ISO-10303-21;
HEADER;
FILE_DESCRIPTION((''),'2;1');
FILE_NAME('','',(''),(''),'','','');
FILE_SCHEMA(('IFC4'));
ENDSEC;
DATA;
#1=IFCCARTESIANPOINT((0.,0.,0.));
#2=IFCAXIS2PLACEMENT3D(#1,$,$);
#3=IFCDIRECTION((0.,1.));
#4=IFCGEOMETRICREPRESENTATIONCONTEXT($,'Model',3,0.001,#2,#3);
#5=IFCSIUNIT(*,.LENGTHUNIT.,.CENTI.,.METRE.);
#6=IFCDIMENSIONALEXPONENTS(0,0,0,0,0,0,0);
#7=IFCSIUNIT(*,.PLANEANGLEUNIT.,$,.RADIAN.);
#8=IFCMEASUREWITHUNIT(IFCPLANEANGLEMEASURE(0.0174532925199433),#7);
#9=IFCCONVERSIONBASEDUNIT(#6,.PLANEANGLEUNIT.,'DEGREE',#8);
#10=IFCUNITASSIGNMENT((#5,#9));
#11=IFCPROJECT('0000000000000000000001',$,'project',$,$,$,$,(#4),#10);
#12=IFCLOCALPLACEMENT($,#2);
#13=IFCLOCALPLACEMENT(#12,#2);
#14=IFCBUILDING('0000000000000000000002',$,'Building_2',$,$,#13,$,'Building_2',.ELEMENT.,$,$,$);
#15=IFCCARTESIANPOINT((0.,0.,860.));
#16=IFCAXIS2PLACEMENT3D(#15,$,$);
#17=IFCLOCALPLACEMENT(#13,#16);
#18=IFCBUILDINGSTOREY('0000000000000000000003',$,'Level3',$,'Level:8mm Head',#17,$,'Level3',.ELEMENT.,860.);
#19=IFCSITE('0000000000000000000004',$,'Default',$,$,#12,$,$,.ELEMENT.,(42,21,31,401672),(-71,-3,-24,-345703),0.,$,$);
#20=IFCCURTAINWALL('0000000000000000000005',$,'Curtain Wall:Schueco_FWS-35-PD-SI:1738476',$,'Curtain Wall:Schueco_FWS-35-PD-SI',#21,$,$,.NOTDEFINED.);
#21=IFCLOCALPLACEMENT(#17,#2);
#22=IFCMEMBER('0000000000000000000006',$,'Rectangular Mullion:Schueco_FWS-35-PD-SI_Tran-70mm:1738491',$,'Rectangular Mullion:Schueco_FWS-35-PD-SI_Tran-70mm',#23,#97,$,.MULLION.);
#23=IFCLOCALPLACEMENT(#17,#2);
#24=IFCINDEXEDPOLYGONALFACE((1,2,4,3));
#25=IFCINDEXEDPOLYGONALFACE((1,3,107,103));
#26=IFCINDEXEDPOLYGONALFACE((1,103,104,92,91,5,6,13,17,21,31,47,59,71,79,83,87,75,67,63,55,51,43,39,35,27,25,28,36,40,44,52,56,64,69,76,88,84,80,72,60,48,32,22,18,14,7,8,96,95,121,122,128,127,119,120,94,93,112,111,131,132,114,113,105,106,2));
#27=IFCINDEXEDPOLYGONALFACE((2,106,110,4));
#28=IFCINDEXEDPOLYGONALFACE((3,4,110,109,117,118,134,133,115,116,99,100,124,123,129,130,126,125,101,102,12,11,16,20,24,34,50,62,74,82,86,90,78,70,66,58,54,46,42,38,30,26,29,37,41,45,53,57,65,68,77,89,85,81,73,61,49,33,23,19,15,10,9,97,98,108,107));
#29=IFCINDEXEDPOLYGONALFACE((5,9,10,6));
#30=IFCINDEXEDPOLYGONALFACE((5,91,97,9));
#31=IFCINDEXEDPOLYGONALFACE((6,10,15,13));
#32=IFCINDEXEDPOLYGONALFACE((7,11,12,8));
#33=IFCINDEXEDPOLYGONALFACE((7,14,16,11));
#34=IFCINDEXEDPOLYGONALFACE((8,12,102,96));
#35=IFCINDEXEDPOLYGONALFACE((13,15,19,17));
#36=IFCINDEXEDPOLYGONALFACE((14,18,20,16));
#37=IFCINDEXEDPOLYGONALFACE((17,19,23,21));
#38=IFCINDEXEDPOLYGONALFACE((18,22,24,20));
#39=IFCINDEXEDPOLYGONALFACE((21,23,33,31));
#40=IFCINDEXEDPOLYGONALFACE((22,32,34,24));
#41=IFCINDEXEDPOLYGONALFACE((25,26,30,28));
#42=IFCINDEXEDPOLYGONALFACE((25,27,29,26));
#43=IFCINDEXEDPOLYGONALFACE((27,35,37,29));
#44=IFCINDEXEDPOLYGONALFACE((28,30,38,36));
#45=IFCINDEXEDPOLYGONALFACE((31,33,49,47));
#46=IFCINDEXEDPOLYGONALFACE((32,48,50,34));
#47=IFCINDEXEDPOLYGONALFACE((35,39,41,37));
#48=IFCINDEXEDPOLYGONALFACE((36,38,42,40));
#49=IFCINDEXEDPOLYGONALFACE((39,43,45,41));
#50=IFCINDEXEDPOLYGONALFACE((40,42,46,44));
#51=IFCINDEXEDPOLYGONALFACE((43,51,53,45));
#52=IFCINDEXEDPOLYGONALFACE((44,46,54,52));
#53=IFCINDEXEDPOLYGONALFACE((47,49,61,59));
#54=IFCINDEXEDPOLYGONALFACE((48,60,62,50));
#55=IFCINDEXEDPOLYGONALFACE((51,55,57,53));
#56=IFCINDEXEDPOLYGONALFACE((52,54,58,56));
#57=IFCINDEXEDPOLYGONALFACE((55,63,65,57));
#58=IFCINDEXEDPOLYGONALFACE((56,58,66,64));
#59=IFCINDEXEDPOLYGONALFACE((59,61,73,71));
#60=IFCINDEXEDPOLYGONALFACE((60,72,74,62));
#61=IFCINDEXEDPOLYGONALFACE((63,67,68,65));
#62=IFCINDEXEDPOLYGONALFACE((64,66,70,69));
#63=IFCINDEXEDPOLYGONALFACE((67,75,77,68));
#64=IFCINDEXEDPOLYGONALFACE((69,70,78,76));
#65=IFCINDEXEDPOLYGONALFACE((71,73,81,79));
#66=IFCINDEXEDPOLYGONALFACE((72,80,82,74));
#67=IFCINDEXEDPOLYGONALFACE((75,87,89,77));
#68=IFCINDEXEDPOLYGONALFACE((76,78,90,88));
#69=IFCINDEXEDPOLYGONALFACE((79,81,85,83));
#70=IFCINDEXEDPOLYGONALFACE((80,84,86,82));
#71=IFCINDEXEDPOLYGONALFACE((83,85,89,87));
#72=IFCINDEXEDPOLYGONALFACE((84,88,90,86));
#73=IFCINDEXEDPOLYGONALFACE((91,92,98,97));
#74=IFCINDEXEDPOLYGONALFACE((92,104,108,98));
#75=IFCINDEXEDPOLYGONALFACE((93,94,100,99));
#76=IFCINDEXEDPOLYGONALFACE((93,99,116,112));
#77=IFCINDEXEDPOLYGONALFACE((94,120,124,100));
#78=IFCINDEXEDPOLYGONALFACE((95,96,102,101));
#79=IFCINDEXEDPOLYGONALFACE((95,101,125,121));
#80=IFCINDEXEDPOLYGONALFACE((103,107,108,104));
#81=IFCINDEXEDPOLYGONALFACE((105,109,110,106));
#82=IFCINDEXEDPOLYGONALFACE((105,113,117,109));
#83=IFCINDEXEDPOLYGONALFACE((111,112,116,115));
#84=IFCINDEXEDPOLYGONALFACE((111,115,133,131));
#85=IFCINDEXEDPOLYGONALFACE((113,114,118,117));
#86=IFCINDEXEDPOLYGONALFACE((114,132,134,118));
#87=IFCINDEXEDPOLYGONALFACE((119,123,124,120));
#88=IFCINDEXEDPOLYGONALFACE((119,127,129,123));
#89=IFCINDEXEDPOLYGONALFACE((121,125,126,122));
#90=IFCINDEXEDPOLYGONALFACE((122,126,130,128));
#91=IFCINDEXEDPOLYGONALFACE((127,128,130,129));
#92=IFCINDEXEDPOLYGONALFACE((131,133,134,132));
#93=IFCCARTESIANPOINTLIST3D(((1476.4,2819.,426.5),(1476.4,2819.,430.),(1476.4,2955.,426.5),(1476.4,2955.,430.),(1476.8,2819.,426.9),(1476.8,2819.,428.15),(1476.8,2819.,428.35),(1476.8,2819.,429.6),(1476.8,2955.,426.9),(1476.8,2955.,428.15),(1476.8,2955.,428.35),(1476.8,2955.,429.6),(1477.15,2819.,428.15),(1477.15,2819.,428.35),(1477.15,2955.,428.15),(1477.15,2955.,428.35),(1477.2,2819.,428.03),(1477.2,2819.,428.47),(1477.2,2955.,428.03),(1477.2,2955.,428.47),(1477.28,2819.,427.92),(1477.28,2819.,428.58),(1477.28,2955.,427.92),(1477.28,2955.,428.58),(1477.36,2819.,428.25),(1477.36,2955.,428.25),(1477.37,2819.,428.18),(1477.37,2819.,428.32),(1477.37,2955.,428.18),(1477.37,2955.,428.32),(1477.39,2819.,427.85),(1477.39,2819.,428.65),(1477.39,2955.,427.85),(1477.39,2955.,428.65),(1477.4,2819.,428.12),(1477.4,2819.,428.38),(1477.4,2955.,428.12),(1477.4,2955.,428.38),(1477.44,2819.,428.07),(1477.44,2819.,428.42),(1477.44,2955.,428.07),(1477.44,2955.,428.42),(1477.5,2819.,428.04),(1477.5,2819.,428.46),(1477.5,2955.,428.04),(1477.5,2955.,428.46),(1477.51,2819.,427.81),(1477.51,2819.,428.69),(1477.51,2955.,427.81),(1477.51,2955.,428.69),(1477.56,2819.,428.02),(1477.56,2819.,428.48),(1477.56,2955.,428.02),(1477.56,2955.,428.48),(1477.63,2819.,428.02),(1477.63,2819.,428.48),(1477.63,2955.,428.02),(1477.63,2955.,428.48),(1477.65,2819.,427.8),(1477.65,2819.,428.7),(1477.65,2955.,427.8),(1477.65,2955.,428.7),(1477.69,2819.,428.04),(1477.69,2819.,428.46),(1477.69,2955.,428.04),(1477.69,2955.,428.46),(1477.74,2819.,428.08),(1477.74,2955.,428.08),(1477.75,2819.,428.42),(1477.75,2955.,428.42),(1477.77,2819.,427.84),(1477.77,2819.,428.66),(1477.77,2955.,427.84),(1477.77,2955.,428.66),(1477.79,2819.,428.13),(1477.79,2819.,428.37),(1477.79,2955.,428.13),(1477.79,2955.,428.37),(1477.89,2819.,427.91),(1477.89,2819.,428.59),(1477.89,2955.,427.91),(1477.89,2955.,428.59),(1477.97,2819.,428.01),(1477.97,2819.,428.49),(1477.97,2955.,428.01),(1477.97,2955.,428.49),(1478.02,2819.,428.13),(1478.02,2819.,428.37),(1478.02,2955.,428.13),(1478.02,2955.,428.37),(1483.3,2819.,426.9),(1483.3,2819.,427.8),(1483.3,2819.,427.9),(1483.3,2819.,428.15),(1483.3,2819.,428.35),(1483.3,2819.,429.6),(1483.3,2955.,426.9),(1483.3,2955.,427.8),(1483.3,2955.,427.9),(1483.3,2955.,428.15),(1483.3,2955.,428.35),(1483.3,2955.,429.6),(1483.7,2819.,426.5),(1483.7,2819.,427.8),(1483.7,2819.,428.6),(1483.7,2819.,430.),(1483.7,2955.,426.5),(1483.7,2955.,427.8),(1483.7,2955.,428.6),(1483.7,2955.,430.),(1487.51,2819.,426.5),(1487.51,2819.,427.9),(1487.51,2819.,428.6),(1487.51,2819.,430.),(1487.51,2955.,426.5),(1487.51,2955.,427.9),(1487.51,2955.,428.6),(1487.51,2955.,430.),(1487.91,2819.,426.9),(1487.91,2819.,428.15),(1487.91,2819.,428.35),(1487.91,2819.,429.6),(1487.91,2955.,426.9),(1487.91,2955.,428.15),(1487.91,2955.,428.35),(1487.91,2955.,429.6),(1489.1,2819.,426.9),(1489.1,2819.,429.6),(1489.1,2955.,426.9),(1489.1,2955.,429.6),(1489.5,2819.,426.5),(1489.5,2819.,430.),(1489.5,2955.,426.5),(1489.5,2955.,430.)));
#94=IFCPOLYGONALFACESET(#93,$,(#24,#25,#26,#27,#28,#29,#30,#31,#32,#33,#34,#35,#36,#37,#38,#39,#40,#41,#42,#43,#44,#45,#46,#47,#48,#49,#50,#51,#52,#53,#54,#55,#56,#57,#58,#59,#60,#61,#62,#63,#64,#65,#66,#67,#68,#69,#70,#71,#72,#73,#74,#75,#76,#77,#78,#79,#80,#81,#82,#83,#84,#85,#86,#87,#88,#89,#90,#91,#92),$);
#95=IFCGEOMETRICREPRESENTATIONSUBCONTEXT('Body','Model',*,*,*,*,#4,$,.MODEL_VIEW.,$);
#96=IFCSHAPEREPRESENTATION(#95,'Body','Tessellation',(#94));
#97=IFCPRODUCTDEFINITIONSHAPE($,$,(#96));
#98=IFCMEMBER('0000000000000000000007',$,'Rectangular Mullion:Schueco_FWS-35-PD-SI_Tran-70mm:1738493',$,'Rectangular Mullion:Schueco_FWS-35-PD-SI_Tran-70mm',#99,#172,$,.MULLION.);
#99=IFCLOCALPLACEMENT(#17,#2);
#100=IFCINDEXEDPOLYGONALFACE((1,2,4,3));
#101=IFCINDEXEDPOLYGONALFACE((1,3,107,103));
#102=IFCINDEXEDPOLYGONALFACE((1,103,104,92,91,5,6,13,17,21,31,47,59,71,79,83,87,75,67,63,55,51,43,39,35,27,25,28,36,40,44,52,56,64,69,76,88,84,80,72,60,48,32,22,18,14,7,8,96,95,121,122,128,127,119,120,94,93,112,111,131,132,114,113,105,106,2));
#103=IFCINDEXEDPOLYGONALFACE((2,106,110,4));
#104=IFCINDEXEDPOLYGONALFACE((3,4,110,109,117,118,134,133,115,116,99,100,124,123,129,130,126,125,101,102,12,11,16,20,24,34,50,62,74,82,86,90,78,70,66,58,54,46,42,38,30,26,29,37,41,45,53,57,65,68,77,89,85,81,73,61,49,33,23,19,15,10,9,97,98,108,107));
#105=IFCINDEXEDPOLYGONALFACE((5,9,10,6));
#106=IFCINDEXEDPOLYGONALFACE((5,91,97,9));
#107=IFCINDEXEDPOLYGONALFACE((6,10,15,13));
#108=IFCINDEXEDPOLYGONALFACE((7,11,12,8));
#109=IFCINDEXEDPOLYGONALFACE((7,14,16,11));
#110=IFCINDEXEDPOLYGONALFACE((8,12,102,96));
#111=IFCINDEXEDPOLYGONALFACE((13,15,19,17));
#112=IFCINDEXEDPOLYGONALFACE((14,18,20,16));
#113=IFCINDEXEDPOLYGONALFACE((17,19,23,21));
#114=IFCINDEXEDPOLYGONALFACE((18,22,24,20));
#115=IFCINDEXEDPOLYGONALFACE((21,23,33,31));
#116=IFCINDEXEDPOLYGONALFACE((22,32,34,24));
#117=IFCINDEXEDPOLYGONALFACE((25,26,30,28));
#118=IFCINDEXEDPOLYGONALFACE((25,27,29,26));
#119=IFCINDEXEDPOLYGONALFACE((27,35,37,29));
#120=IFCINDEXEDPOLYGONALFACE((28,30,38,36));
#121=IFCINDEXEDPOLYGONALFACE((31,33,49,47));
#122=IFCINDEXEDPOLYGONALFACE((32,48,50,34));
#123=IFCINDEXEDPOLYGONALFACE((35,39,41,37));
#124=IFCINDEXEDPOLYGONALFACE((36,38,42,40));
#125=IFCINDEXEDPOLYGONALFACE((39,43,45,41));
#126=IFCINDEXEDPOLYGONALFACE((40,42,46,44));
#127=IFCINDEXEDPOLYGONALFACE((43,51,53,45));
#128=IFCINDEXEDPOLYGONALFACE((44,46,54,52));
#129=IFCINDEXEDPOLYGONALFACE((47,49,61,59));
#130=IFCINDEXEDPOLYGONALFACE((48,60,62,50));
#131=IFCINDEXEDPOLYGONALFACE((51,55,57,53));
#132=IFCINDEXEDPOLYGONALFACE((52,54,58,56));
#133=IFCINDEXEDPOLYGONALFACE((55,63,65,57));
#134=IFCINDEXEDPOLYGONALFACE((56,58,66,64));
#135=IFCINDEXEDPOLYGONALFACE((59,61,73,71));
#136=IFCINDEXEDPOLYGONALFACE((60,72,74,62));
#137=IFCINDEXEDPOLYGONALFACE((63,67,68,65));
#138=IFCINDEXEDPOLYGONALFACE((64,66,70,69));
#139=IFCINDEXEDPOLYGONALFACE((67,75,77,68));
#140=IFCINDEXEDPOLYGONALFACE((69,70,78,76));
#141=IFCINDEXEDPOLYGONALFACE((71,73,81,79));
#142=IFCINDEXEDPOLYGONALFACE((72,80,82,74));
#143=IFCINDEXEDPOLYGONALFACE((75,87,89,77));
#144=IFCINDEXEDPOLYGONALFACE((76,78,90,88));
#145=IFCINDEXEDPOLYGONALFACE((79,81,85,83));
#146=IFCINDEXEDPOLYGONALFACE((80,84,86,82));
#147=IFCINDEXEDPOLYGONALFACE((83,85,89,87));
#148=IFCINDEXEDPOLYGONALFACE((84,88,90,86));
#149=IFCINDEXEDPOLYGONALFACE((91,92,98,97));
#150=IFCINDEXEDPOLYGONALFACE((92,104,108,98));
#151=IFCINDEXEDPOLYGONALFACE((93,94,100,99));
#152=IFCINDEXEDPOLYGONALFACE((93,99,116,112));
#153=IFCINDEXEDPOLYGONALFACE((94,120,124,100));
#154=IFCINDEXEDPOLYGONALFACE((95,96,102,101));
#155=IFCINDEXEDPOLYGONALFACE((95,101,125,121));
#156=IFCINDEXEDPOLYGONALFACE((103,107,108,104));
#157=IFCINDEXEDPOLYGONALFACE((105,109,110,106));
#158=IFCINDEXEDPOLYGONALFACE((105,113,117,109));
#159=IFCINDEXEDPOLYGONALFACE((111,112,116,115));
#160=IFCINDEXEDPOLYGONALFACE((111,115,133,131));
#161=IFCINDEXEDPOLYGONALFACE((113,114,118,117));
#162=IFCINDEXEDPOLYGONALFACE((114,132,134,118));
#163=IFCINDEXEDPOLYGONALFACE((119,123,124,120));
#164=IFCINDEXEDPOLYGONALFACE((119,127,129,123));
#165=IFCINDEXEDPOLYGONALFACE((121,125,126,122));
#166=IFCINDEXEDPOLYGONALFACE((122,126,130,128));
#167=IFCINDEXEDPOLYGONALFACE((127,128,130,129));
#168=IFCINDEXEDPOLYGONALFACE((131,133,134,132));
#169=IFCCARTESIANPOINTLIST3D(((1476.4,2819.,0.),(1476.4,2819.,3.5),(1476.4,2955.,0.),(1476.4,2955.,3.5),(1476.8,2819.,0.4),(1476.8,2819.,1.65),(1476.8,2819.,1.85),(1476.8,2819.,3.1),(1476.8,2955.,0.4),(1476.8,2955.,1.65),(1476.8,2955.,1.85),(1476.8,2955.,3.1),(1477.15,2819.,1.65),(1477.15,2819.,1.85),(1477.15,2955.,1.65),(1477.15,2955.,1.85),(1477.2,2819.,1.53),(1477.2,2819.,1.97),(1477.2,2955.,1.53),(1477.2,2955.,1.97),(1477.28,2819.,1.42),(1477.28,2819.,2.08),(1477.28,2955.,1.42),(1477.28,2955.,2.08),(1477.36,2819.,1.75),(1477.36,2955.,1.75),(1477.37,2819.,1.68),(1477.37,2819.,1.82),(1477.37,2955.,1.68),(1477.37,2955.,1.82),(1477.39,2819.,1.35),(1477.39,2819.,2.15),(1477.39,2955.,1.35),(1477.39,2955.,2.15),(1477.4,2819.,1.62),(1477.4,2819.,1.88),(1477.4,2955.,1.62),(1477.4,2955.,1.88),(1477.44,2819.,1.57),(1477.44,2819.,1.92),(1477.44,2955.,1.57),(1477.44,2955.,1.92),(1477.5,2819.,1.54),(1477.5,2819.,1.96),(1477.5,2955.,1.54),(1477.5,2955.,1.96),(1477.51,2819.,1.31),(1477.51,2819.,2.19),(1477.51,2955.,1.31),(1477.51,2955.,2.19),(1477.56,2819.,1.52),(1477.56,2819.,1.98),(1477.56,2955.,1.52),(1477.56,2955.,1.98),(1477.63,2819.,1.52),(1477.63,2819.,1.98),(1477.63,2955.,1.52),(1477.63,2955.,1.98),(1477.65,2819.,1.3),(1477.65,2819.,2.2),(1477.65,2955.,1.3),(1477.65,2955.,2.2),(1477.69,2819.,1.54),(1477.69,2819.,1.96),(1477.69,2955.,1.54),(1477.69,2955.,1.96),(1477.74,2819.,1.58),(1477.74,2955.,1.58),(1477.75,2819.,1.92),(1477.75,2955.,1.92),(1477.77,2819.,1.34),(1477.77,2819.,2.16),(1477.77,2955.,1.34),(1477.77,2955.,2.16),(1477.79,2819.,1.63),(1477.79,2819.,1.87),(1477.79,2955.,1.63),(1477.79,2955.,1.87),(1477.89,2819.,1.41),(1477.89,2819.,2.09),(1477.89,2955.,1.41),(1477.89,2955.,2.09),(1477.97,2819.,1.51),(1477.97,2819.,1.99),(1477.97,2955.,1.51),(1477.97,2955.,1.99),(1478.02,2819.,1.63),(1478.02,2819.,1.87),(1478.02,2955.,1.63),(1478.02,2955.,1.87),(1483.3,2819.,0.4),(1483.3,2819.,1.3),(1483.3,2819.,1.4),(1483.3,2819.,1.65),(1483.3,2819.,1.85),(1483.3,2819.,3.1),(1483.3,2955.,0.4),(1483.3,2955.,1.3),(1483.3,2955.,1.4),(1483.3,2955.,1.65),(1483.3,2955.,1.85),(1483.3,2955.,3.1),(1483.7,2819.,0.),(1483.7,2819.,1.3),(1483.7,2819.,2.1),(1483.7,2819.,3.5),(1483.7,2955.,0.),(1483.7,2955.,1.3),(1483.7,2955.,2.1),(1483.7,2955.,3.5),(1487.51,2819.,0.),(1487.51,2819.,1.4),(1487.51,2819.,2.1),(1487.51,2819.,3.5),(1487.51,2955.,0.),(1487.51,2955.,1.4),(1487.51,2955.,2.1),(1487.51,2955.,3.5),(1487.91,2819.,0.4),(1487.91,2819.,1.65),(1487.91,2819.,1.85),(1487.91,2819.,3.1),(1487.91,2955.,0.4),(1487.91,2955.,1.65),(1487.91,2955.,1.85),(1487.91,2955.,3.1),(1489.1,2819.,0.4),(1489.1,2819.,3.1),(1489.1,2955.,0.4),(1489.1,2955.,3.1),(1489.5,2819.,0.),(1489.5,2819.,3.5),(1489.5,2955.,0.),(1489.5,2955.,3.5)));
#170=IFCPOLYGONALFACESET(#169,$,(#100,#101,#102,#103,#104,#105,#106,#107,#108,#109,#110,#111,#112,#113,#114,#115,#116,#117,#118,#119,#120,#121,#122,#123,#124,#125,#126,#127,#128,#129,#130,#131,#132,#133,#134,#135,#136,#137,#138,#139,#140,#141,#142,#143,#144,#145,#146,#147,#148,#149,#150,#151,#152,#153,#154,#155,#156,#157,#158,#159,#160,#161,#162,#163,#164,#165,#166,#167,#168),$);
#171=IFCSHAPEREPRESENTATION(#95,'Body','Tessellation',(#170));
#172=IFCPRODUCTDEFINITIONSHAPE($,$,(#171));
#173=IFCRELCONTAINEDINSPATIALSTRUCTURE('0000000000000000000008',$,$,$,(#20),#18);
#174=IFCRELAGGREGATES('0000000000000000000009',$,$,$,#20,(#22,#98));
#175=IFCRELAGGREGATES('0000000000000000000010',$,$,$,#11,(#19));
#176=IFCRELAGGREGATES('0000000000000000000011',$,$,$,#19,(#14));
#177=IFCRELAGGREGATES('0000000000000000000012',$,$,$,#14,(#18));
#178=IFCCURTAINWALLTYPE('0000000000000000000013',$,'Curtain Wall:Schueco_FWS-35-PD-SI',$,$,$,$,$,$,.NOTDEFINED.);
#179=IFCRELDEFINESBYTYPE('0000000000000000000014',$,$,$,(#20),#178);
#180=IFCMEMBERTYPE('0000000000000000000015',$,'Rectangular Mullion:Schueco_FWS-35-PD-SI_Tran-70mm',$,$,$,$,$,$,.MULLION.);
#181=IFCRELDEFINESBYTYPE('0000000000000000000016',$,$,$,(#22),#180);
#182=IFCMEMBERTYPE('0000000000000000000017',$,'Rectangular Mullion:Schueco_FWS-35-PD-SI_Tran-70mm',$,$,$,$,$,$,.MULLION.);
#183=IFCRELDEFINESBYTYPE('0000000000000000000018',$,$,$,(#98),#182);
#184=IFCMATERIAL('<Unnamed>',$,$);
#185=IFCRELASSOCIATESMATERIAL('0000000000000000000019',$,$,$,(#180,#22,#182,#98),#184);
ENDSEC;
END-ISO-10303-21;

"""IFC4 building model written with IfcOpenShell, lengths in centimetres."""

from ifc_helpers import new_model, entity, si_unit, converted_unit, direction, frame, origin, place, context, subcontext, project, spatial, line, arc, indexed_curve, outline, extrude, source, transform, mapped, material, type_object, type_shapes, element, aggregate, save


model = new_model("IFC4")

# Units and contexts
model_context = context("Model", 3, precision=0.001, world=origin(), true_north=direction((0.0, 1.0)))
body_context = subcontext(model_context, "Body", "Model", "MODEL_VIEW")
ifc_project = project(units=[si_unit("LENGTHUNIT", "METRE", prefix="CENTI"), converted_unit("PLANEANGLEUNIT", "DEGREE", entity("IfcPlaneAngleMeasure", 0.0174532925199433), si_unit("PLANEANGLEUNIT", "RADIAN"), dimensions=[0, 0, 0, 0, 0, 0, 0])], contexts=[model_context])

# Site, building, storey
site_placement = place(None, origin())
site = spatial("IfcSite", under=ifc_project, at=site_placement, Name="Default", CompositionType="ELEMENT", RefLatitude=(42, 21, 31, 401672), RefLongitude=(-71, -3, -24, -345703), RefElevation=0.0)
building_placement = place(site_placement, origin())
building = spatial("IfcBuilding", under=site, at=building_placement, Name="Building_2", LongName="Building_2", CompositionType="ELEMENT")
storey_placement = place(building_placement, frame((0.0, 0.0, 860.0)))
storey = spatial("IfcBuildingStorey", under=building, at=storey_placement, Name="Level3", ObjectType="Level:8mm Head", LongName="Level3", CompositionType="ELEMENT", Elevation=860.0)

# Curtain wall, members
curtain_wall_type = type_object("IfcCurtainWallType", Name="Curtain Wall:Schueco_FWS-35-PD-SI", PredefinedType="NOTDEFINED")
curtain_wall_placement = place(storey_placement, frame((0.0, 0.0, -860.0)))
curtain_wall = element("IfcCurtainWall", 1, at=curtain_wall_placement, inside=storey, type_object=curtain_wall_type, Name="Curtain Wall:Schueco_FWS-35-PD-SI:1738476", ObjectType="Curtain Wall:Schueco_FWS-35-PD-SI", PredefinedType="NOTDEFINED")
ifc_material_1 = material(Name="<Unnamed>")
member_type_1 = type_object("IfcMemberType", Name="Rectangular Mullion:Schueco_FWS-35-PD-SI_Tran-70mm", PredefinedType="MULLION", material=ifc_material_1)
shared_shape_1 = source(origin(), body_context, "Body", "SweptSolid", [
    extrude(outline(indexed_curve([(-1.78, -6.52), (1.72, -6.52), (1.72, 0.78), (0.42, 0.78), (0.42, 0.38), (1.32, 0.38), (1.32, -6.12), (0.07, -6.12), (0.07, -5.77), (0.42, -5.34), (0.09, -4.9), (0.09, -5.14), (-0.03, -5.56), (-0.15, -5.14), (-0.15, -4.9), (-0.48, -5.34), (-0.13, -5.77), (-0.13, -6.12), (-1.38, -6.12), (-1.38, 0.38), (-0.13, 0.38), (-0.13, 4.99), (-1.38, 4.99), (-1.38, 6.18), (1.32, 6.18), (1.32, 4.99), (0.07, 4.99), (0.07, 0.38), (0.32, 0.38), (0.32, 4.59), (1.72, 4.59), (1.72, 6.58), (-1.78, 6.58), (-1.78, 4.59), (-0.38, 4.59), (-0.38, 0.78), (-1.78, 0.78)], segments=[line(1, 2, 3, 4, 5, 6, 7, 8, 9), arc(9, 10, 11), line(11, 12), arc(12, 13, 14), line(14, 15), arc(15, 16, 17), line(17, 18, 19, 20, 21, 22, 23, 24, 25, 26, 27, 28, 29, 30, 31, 32, 33, 34, 35, 36, 37, 1)], self_intersect=False)), frame((-1.78, 4.58, -136.0), z_axis=(0.0, 0.0, 1.0), x_axis=(-1.0, 0.0, 0.0)), (0.0, 0.0, 1.0), 136.0),
])
type_shapes(member_type_1, [shared_shape_1])
member_1_placement = place(curtain_wall_placement, frame((1487.5, 2819.0, 1290.0), z_axis=(0.0, -1.0, 0.0), x_axis=(0.0, 0.0, 1.0)))
member_1 = element("IfcMember", 2, at=member_1_placement, type_object=member_type_1, material=ifc_material_1, Name="Rectangular Mullion:Schueco_FWS-35-PD-SI_Tran-70mm:1738491", ObjectType="Rectangular Mullion:Schueco_FWS-35-PD-SI_Tran-70mm", PredefinedType="MULLION", context=body_context, shape_type="MappedRepresentation", body=[
    mapped(shared_shape_1, transform((0.0, 0.0, 0.0), scale=1.0)),
])
member_type_2 = type_object("IfcMemberType", Name="Rectangular Mullion:Schueco_FWS-35-PD-SI_Tran-70mm", PredefinedType="MULLION", material=ifc_material_1)
shared_shape_2 = source(origin(), body_context, "Body", "SweptSolid", [
    extrude(outline(indexed_curve([(-6.52, -1.78), (0.78, -1.78), (0.78, -0.38), (4.59, -0.38), (4.59, -1.78), (6.58, -1.78), (6.58, 1.72), (4.59, 1.72), (4.59, 0.32), (0.38, 0.32), (0.38, 0.07), (4.99, 0.07), (4.99, 1.32), (6.18, 1.32), (6.18, -1.38), (4.99, -1.38), (4.99, -0.13), (0.38, -0.13), (0.38, -1.38), (-6.12, -1.38), (-6.12, -0.13), (-5.77, -0.13), (-5.34, -0.48), (-4.9, -0.15), (-5.14, -0.15), (-5.56, -0.03), (-5.14, 0.09), (-4.9, 0.09), (-5.34, 0.42), (-5.77, 0.07), (-6.12, 0.07), (-6.12, 1.32), (0.38, 1.32), (0.38, 0.42), (0.78, 0.42), (0.78, 1.72), (-6.52, 1.72)], segments=[line(1, 2, 3, 4, 5, 6, 7, 8, 9, 10, 11, 12, 13, 14, 15, 16, 17, 18, 19, 20, 21, 22), arc(22, 23, 24), line(24, 25), arc(25, 26, 27), line(27, 28), arc(28, 29, 30), line(30, 31, 32, 33, 34, 35, 36, 37, 1)], self_intersect=False)), frame((-1.72, 4.58, -136.0), z_axis=(0.0, 0.0, 1.0), x_axis=(0.0, -1.0, 0.0)), (0.0, 0.0, 1.0), 136.0),
])
type_shapes(member_type_2, [shared_shape_2])
member_2_placement = place(curtain_wall_placement, frame((1487.5, 2955.0, 860.0), z_axis=(0.0, 1.0, 0.0), x_axis=(0.0, 0.0, -1.0)))
member_2 = element("IfcMember", 3, at=member_2_placement, type_object=member_type_2, material=ifc_material_1, Name="Rectangular Mullion:Schueco_FWS-35-PD-SI_Tran-70mm:1738493", ObjectType="Rectangular Mullion:Schueco_FWS-35-PD-SI_Tran-70mm", PredefinedType="MULLION", context=body_context, shape_type="MappedRepresentation", body=[
    mapped(shared_shape_2, transform((0.0, 0.0, 0.0), scale=1.0)),
])
aggregate(curtain_wall, [member_1, member_2])

save(model, "model.ifc")
